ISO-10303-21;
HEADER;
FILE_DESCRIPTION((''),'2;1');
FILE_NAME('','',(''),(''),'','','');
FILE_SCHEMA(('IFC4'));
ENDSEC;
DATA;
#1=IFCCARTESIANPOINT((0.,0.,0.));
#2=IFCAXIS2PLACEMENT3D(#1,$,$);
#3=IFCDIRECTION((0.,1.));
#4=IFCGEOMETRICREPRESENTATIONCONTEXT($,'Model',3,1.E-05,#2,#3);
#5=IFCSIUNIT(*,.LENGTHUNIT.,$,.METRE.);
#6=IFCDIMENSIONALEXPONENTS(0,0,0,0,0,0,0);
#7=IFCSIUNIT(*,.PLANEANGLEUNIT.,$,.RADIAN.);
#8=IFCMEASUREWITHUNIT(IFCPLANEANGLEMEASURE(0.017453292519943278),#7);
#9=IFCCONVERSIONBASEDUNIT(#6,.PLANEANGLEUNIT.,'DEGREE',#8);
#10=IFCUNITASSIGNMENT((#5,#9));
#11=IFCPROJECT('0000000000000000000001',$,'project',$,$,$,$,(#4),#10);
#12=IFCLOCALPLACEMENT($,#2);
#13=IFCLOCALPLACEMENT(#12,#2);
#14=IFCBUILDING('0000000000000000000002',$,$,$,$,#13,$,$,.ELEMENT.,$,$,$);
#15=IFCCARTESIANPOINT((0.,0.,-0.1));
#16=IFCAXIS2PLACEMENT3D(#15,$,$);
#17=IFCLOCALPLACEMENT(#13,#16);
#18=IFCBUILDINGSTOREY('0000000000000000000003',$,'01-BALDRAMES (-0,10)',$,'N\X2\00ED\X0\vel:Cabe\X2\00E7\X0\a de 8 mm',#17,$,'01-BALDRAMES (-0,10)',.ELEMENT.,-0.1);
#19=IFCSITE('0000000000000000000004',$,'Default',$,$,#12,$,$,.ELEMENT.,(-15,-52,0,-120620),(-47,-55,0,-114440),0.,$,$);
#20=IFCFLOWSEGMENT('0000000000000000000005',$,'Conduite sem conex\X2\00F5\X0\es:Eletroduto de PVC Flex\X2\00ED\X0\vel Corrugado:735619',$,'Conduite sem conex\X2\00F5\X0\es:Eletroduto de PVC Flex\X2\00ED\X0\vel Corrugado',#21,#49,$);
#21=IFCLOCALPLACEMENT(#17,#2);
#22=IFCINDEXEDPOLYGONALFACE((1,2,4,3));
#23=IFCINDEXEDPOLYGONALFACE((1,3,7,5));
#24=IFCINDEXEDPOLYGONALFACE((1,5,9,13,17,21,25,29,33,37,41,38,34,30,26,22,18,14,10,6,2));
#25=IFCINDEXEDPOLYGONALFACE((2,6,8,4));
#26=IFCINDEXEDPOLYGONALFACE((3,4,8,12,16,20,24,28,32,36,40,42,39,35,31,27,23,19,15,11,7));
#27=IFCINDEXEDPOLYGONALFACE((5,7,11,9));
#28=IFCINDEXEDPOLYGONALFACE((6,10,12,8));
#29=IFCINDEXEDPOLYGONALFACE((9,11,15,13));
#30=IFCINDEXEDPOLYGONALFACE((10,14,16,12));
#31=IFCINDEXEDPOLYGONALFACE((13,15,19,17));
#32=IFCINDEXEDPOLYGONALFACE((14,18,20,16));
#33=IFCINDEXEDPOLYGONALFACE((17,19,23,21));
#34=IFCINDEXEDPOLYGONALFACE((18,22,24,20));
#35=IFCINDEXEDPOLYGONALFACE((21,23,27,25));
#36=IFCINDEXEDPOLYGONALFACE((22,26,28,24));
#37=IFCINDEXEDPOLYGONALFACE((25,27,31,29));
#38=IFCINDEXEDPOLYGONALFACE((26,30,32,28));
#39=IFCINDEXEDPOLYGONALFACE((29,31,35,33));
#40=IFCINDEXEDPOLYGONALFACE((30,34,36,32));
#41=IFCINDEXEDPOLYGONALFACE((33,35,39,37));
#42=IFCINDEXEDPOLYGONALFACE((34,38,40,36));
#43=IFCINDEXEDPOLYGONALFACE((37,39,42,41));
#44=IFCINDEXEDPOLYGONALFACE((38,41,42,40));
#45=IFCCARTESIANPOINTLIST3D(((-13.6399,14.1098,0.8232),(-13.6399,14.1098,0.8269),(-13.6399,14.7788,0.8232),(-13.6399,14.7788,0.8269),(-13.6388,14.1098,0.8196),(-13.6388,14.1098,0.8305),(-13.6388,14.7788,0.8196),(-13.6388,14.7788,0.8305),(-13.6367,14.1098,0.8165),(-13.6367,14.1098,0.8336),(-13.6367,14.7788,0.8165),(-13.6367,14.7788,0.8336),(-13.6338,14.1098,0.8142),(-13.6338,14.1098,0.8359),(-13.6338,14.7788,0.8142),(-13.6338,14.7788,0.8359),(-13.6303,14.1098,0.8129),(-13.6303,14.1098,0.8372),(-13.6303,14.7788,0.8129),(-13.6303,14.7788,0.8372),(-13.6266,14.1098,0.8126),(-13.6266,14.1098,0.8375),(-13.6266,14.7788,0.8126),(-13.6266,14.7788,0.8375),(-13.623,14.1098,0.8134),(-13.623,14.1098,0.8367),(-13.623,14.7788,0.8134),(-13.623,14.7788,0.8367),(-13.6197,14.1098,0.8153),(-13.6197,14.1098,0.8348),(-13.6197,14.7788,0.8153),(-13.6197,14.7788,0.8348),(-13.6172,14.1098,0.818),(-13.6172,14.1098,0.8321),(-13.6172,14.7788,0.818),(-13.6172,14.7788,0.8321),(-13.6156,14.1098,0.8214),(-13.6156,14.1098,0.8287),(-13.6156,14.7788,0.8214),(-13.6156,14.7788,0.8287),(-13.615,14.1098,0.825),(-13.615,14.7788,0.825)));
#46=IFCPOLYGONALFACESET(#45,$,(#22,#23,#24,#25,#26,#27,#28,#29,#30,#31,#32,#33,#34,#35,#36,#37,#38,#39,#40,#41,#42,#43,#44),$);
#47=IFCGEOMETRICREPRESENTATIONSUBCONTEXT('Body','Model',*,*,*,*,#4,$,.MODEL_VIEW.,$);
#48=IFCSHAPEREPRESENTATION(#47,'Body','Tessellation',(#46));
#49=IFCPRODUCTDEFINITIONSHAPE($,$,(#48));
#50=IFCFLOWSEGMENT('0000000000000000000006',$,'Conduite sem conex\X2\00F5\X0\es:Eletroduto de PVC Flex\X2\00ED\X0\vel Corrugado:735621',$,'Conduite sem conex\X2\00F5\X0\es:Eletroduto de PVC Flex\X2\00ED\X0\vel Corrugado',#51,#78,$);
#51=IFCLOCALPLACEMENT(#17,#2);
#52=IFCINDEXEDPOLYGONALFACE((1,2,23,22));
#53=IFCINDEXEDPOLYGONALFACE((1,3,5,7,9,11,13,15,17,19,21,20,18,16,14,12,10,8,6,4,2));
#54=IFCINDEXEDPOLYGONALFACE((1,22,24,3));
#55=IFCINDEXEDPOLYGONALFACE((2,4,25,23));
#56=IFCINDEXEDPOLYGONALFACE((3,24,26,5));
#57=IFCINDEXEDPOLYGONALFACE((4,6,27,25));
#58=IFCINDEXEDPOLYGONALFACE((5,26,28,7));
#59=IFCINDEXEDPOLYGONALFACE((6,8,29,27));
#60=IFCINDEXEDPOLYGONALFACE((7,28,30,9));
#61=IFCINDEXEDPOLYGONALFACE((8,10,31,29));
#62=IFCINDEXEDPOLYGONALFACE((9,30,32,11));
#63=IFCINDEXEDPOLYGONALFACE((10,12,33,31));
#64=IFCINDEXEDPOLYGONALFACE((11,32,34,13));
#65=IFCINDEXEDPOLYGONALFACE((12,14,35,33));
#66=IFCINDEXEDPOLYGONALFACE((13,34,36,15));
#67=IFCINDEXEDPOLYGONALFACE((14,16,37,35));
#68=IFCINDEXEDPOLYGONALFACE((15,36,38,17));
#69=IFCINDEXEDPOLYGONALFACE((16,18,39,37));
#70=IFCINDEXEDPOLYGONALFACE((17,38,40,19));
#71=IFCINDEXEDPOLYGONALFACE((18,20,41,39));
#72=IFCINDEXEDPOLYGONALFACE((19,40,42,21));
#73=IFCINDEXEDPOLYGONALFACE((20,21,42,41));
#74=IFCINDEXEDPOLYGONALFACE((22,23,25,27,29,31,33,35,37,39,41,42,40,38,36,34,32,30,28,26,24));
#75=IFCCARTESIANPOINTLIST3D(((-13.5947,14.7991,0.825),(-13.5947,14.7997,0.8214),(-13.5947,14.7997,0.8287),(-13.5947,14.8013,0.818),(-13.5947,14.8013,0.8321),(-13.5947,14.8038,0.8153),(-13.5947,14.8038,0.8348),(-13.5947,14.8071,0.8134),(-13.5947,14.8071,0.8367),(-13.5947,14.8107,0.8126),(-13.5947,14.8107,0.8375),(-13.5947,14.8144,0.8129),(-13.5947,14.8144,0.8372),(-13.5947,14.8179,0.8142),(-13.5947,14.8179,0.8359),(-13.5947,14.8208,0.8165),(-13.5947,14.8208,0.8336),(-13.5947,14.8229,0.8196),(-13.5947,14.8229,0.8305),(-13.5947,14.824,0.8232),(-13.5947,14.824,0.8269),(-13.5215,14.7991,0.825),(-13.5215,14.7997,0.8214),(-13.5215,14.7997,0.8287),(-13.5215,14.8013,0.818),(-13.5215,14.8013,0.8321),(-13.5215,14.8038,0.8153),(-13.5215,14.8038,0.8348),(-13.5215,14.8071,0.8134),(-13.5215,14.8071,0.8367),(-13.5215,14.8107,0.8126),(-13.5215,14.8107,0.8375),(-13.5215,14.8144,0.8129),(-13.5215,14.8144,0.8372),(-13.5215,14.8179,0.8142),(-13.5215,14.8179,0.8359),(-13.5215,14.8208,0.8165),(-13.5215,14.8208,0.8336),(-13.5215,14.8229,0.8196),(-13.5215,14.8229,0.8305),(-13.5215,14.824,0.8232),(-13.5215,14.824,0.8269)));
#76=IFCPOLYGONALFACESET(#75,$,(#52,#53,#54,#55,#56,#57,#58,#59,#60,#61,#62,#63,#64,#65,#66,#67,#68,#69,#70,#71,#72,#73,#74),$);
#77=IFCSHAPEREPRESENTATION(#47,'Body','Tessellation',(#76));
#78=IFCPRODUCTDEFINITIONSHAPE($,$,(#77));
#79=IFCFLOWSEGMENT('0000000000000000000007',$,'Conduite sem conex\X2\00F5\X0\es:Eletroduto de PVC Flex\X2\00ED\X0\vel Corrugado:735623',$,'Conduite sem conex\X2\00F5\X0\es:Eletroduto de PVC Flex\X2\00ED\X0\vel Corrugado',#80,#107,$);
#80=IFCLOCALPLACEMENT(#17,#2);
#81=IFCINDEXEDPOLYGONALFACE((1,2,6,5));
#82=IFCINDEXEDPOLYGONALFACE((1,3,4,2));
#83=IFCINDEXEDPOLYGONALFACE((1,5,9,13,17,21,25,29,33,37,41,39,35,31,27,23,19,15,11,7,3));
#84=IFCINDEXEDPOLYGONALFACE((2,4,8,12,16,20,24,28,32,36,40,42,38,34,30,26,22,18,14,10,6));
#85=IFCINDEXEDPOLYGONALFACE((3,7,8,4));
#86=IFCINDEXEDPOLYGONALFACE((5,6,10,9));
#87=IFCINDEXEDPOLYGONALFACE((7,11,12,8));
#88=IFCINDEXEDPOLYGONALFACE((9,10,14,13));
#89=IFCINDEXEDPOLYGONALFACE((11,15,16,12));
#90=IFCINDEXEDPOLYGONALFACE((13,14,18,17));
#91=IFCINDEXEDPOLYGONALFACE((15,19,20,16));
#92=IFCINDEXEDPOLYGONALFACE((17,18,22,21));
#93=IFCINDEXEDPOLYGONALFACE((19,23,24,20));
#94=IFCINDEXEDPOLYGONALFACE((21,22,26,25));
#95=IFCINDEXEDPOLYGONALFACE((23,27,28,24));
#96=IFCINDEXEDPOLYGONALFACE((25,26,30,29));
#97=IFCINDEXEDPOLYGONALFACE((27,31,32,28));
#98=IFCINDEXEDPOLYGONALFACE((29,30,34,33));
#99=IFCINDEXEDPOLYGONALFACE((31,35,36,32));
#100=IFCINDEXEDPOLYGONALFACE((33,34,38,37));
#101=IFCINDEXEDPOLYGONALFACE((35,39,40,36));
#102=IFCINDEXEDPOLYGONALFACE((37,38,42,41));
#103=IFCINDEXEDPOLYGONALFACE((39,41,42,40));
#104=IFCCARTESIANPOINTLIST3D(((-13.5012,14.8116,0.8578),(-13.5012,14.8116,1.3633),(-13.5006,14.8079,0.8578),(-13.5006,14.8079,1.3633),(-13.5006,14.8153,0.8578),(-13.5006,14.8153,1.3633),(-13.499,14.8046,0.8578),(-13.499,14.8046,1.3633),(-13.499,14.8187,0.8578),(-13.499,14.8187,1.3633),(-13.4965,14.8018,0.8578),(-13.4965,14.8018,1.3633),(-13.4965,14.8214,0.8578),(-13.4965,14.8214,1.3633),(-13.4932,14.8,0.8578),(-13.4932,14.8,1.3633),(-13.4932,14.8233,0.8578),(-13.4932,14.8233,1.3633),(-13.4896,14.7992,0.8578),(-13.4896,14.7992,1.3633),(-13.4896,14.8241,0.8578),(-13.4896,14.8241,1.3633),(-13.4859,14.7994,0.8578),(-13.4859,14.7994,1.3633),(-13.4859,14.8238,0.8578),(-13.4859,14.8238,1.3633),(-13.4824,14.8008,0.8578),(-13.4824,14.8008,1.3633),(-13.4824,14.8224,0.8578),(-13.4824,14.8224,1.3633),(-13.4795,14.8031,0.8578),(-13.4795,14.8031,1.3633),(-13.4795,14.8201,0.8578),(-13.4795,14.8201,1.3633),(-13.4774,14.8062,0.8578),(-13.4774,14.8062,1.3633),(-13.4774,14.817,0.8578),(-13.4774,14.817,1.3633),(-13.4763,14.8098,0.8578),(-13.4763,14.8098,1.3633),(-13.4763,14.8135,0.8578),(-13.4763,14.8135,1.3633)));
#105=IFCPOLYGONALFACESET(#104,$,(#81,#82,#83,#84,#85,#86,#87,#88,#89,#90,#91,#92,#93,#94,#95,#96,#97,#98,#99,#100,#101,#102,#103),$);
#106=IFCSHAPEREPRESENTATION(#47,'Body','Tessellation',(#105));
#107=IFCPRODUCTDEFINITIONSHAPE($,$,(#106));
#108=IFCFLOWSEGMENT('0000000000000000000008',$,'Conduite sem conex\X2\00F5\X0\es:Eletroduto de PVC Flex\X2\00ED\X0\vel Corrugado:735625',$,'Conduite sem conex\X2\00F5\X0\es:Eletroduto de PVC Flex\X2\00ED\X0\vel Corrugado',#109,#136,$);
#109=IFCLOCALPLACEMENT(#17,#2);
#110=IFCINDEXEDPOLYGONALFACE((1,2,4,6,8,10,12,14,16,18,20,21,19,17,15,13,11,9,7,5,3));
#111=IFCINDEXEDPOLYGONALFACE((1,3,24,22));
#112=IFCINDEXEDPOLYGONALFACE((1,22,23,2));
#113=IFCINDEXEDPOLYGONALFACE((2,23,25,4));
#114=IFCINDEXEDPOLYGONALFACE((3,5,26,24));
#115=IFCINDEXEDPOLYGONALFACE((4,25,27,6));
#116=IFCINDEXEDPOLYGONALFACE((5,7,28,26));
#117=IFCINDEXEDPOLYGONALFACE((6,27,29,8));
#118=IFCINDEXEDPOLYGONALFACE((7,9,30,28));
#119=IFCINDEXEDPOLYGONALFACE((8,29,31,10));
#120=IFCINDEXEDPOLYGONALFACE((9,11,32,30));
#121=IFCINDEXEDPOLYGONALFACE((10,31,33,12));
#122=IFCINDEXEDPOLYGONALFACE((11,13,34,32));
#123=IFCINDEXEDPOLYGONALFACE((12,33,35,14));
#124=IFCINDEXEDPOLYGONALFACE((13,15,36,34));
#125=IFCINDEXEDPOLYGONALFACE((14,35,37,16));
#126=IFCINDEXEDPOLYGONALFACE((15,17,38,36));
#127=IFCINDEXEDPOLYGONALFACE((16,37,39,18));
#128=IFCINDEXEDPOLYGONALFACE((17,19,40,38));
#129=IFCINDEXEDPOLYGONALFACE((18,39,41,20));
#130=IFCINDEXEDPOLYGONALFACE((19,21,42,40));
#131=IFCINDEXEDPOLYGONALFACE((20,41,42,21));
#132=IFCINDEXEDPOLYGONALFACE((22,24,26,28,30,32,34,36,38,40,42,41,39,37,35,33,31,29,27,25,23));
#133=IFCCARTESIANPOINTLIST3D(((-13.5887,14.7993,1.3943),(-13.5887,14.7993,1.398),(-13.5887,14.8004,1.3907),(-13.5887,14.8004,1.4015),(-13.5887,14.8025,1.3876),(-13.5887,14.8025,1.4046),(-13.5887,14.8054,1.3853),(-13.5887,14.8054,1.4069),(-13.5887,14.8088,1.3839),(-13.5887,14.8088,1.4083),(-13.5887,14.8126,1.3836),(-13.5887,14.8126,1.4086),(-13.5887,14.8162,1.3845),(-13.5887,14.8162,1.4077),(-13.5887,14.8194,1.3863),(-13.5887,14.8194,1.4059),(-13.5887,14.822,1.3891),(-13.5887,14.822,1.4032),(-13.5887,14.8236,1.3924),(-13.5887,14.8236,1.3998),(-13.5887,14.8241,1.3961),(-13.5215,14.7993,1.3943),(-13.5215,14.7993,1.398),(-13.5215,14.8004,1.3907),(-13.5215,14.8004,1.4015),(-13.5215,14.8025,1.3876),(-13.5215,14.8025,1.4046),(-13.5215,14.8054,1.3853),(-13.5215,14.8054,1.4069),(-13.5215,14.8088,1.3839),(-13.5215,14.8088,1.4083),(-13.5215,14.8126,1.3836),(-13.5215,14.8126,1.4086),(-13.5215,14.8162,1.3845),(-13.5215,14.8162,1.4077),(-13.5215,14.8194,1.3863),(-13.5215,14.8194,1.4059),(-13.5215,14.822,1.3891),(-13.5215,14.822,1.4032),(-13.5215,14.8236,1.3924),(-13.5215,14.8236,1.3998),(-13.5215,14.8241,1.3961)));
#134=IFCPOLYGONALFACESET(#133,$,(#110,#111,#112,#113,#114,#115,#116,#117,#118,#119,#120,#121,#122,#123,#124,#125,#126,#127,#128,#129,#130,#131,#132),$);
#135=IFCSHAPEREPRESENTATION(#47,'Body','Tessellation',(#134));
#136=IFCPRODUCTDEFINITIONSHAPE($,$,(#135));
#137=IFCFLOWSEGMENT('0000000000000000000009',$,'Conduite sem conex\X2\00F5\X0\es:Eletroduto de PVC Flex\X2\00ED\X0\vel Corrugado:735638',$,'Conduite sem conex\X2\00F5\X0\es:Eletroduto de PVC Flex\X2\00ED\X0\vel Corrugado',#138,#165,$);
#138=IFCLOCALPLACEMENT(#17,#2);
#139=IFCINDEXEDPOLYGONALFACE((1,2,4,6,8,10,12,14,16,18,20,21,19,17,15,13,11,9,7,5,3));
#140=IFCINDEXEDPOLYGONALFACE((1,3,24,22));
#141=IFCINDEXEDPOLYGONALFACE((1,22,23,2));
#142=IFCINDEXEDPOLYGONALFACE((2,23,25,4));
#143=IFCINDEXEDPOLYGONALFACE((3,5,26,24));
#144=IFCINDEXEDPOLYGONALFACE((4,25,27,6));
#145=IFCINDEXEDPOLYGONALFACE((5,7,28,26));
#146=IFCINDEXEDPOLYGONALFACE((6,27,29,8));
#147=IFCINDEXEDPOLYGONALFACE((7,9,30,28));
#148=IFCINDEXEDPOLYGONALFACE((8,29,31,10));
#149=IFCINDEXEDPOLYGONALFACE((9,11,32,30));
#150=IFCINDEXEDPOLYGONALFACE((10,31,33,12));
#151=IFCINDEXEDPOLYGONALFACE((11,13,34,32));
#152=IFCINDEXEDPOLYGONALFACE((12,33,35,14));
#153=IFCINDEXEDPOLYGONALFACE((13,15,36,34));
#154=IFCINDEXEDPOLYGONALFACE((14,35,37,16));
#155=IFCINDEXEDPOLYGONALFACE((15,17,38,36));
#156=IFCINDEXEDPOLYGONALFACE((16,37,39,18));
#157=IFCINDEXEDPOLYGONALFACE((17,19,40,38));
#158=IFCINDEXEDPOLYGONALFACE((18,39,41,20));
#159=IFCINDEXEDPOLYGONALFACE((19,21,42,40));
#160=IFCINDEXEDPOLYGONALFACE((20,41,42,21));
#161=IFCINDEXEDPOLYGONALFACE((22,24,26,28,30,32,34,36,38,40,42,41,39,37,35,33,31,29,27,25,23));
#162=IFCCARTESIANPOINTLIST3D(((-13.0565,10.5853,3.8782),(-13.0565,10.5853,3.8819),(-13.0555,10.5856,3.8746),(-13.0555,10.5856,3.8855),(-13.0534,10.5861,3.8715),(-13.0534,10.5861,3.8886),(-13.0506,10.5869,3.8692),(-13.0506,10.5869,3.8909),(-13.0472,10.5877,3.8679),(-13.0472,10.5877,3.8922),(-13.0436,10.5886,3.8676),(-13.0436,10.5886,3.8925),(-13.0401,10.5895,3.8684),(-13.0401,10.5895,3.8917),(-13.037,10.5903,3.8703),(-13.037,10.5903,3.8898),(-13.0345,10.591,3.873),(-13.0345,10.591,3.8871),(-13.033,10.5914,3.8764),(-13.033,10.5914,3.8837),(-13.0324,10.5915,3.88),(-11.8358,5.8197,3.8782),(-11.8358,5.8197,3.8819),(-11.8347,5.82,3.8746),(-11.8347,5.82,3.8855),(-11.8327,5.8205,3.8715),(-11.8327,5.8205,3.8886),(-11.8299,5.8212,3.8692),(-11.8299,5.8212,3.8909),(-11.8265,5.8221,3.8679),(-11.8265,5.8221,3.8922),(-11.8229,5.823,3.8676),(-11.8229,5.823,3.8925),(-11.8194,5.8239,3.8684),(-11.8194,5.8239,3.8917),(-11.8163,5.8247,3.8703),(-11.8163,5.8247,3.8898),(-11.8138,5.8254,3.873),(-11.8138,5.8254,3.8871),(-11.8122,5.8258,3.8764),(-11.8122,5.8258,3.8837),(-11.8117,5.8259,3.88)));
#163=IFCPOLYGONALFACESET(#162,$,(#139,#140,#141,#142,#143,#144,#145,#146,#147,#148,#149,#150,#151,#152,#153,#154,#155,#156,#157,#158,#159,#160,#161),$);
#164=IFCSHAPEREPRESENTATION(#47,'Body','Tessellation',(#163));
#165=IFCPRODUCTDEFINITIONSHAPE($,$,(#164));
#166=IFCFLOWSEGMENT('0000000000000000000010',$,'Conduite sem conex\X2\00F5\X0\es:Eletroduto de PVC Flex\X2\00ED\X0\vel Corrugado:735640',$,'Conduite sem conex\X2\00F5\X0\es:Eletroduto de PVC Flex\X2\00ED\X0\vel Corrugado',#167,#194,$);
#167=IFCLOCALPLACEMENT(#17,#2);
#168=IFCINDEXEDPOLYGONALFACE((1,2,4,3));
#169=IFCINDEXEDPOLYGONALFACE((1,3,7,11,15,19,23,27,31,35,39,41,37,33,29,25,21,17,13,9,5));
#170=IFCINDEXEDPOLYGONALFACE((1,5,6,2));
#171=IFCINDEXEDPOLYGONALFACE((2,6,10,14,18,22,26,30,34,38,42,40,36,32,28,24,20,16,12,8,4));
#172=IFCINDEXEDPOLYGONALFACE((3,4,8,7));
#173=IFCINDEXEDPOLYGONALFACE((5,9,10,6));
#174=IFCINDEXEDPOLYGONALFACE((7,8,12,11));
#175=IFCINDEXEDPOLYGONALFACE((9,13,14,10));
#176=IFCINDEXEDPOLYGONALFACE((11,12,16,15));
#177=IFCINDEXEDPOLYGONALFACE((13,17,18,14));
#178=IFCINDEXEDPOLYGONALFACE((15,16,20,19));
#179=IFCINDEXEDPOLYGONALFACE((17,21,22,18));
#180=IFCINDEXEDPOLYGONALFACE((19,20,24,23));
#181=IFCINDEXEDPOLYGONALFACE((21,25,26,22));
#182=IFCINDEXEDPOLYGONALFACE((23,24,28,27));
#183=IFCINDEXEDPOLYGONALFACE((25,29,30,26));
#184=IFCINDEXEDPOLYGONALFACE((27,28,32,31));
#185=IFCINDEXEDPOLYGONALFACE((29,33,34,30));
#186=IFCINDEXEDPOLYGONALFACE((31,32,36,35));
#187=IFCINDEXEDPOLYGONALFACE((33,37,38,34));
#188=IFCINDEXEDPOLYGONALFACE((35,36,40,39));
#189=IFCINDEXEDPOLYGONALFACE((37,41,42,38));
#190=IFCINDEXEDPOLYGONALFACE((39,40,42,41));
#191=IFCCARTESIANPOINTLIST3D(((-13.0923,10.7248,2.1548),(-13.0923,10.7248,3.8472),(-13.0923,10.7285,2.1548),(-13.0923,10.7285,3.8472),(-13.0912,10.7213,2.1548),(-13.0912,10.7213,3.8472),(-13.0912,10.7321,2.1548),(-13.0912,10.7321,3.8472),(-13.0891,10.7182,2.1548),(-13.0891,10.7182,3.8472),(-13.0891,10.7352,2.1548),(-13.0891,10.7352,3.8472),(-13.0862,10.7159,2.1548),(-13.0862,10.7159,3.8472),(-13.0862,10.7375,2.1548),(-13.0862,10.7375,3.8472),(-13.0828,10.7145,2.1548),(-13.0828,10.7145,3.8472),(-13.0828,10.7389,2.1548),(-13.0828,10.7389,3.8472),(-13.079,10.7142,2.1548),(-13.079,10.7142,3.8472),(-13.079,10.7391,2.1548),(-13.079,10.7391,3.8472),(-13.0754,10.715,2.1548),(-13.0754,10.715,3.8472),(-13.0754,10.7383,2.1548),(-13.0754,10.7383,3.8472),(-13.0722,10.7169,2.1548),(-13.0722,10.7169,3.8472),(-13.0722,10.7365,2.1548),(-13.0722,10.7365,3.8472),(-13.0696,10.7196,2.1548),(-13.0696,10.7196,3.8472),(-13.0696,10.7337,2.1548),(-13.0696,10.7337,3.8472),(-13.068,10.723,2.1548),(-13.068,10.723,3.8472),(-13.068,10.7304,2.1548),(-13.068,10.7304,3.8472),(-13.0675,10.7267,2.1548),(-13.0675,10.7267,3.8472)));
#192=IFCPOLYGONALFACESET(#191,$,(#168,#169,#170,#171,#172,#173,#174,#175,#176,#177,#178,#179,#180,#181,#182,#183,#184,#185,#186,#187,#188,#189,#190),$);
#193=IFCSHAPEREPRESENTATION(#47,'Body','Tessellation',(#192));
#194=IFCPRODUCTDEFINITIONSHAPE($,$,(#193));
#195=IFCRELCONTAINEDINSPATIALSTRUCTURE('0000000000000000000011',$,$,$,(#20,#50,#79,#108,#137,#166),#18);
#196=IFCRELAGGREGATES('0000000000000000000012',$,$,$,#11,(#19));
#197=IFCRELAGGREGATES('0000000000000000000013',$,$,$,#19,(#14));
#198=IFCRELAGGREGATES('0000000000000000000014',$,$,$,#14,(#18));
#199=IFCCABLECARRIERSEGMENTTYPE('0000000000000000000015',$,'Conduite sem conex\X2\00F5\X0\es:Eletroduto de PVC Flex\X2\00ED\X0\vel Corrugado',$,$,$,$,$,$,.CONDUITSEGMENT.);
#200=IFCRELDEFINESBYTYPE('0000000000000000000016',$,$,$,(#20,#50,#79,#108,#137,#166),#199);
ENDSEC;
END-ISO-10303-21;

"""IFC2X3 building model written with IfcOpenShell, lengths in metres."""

from ifc_helpers import new_model, entity, si_unit, converted_unit, direction, frame, frame_2d, origin, origin_2d_with_axis, place, context, subcontext, project, spatial, circle, extrude, type_object, element, save


model = new_model("IFC2X3")

# Units and contexts
model_context = context("Model", 3, precision=1e-05, world=origin(), true_north=direction((0.0, 1.0)))
body_context = subcontext(model_context, "Body", "Model", "MODEL_VIEW")
ifc_project = project(units=[si_unit("LENGTHUNIT", "METRE"), converted_unit("PLANEANGLEUNIT", "DEGREE", entity("IfcPlaneAngleMeasure", 0.017453292519943278), si_unit("PLANEANGLEUNIT", "RADIAN"), dimensions=[0, 0, 0, 0, 0, 0, 0])], contexts=[model_context])

# Site, building, storey
site_placement = place(None, origin())
site = spatial("IfcSite", under=ifc_project, at=site_placement, Name="Default", CompositionType="ELEMENT", RefLatitude=(-15, -52, 0, -120620), RefLongitude=(-47, -55, 0, -114440), RefElevation=0.0)
building_placement = place(site_placement, origin())
building = spatial("IfcBuilding", under=site, at=building_placement, CompositionType="ELEMENT")
storey_placement = place(building_placement, frame((0.0, 0.0, -0.1)))
storey = spatial("IfcBuildingStorey", under=building, at=storey_placement, Name="01-BALDRAMES (-0,10)", ObjectType="Nível:Cabeça de 8 mm", LongName="01-BALDRAMES (-0,10)", CompositionType="ELEMENT", Elevation=-0.1)

# Flow segments
cable_carrier_segment_type = type_object("IfcCableCarrierSegmentType", Name="Conduite sem conexões:Eletroduto de PVC Flexível Corrugado", PredefinedType="CONDUITSEGMENT")
flow_segment_1_placement = place(storey_placement, origin())
element("IfcFlowSegment", 1, at=flow_segment_1_placement, inside=storey, type_object=cable_carrier_segment_type, Name="Conduite sem conexões:Eletroduto de PVC Flexível Corrugado:735619", ObjectType="Conduite sem conexões:Eletroduto de PVC Flexível Corrugado", context=body_context, shape_type="SweptSolid", body=[
    extrude(circle(Radius=0.0125, at=frame_2d((0.0, 0.0), x_axis=(1.0, 0.0))), frame((-13.6275, 14.1098, 0.825), z_axis=(0.0, 1.0, 0.0), x_axis=(1.0, 0.0, 0.0)), (0.0, 0.0, 1.0), 0.669),
])
flow_segment_2_placement = place(storey_placement, origin())
element("IfcFlowSegment", 2, at=flow_segment_2_placement, inside=storey, type_object=cable_carrier_segment_type, Name="Conduite sem conexões:Eletroduto de PVC Flexível Corrugado:735621", ObjectType="Conduite sem conexões:Eletroduto de PVC Flexível Corrugado", context=body_context, shape_type="SweptSolid", body=[
    extrude(circle(Radius=0.0125, at=origin_2d_with_axis()), frame((-13.5947, 14.8116, 0.825), z_axis=(1.0, 0.0, 0.0), x_axis=(0.0, -1.0, 0.0)), (0.0, 0.0, 1.0), 0.0733),
])
flow_segment_3_placement = place(storey_placement, origin())
element("IfcFlowSegment", 3, at=flow_segment_3_placement, inside=storey, type_object=cable_carrier_segment_type, Name="Conduite sem conexões:Eletroduto de PVC Flexível Corrugado:735623", ObjectType="Conduite sem conexões:Eletroduto de PVC Flexível Corrugado", context=body_context, shape_type="SweptSolid", body=[
    extrude(circle(Radius=0.0125, at=origin_2d_with_axis()), frame((-13.4887, 14.8116, 0.8578), z_axis=(0.0, 0.0, 1.0), x_axis=(-1.0, 0.0, 0.0)), (0.0, 0.0, 1.0), 0.5055),
])
flow_segment_4_placement = place(storey_placement, origin())
element("IfcFlowSegment", 4, at=flow_segment_4_placement, inside=storey, type_object=cable_carrier_segment_type, Name="Conduite sem conexões:Eletroduto de PVC Flexível Corrugado:735625", ObjectType="Conduite sem conexões:Eletroduto de PVC Flexível Corrugado", context=body_context, shape_type="SweptSolid", body=[
    extrude(circle(Radius=0.0125, at=frame_2d((0.0, 0.0), x_axis=(1.0, 0.0))), frame((-13.5887, 14.8116, 1.3961), z_axis=(1.0, 0.0, 0.0), x_axis=(0.0, 1.0, 0.0)), (0.0, 0.0, 1.0), 0.0672),
])
flow_segment_5_placement = place(storey_placement, origin())
element("IfcFlowSegment", 5, at=flow_segment_5_placement, inside=storey, type_object=cable_carrier_segment_type, Name="Conduite sem conexões:Eletroduto de PVC Flexível Corrugado:735638", ObjectType="Conduite sem conexões:Eletroduto de PVC Flexível Corrugado", context=body_context, shape_type="SweptSolid", body=[
    extrude(circle(Radius=0.0125, at=frame_2d((0.0, 0.0), x_axis=(1.0, 0.0))), frame((-13.0446, 10.5884, 3.88), z_axis=(0.248143, -0.968723, 0.0), x_axis=(0.968723, 0.248143, 0.0)), (0.0, 0.0, 1.0), 4.9195),
])
flow_segment_6_placement = place(storey_placement, origin())
element("IfcFlowSegment", 6, at=flow_segment_6_placement, inside=storey, type_object=cable_carrier_segment_type, Name="Conduite sem conexões:Eletroduto de PVC Flexível Corrugado:735640", ObjectType="Conduite sem conexões:Eletroduto de PVC Flexível Corrugado", context=body_context, shape_type="SweptSolid", body=[
    extrude(circle(Radius=0.0125, at=origin_2d_with_axis()), frame((-13.08, 10.7267, 2.1548)), (0.0, 0.0, 1.0), 1.6925),
])

save(model, "model.ifc")
